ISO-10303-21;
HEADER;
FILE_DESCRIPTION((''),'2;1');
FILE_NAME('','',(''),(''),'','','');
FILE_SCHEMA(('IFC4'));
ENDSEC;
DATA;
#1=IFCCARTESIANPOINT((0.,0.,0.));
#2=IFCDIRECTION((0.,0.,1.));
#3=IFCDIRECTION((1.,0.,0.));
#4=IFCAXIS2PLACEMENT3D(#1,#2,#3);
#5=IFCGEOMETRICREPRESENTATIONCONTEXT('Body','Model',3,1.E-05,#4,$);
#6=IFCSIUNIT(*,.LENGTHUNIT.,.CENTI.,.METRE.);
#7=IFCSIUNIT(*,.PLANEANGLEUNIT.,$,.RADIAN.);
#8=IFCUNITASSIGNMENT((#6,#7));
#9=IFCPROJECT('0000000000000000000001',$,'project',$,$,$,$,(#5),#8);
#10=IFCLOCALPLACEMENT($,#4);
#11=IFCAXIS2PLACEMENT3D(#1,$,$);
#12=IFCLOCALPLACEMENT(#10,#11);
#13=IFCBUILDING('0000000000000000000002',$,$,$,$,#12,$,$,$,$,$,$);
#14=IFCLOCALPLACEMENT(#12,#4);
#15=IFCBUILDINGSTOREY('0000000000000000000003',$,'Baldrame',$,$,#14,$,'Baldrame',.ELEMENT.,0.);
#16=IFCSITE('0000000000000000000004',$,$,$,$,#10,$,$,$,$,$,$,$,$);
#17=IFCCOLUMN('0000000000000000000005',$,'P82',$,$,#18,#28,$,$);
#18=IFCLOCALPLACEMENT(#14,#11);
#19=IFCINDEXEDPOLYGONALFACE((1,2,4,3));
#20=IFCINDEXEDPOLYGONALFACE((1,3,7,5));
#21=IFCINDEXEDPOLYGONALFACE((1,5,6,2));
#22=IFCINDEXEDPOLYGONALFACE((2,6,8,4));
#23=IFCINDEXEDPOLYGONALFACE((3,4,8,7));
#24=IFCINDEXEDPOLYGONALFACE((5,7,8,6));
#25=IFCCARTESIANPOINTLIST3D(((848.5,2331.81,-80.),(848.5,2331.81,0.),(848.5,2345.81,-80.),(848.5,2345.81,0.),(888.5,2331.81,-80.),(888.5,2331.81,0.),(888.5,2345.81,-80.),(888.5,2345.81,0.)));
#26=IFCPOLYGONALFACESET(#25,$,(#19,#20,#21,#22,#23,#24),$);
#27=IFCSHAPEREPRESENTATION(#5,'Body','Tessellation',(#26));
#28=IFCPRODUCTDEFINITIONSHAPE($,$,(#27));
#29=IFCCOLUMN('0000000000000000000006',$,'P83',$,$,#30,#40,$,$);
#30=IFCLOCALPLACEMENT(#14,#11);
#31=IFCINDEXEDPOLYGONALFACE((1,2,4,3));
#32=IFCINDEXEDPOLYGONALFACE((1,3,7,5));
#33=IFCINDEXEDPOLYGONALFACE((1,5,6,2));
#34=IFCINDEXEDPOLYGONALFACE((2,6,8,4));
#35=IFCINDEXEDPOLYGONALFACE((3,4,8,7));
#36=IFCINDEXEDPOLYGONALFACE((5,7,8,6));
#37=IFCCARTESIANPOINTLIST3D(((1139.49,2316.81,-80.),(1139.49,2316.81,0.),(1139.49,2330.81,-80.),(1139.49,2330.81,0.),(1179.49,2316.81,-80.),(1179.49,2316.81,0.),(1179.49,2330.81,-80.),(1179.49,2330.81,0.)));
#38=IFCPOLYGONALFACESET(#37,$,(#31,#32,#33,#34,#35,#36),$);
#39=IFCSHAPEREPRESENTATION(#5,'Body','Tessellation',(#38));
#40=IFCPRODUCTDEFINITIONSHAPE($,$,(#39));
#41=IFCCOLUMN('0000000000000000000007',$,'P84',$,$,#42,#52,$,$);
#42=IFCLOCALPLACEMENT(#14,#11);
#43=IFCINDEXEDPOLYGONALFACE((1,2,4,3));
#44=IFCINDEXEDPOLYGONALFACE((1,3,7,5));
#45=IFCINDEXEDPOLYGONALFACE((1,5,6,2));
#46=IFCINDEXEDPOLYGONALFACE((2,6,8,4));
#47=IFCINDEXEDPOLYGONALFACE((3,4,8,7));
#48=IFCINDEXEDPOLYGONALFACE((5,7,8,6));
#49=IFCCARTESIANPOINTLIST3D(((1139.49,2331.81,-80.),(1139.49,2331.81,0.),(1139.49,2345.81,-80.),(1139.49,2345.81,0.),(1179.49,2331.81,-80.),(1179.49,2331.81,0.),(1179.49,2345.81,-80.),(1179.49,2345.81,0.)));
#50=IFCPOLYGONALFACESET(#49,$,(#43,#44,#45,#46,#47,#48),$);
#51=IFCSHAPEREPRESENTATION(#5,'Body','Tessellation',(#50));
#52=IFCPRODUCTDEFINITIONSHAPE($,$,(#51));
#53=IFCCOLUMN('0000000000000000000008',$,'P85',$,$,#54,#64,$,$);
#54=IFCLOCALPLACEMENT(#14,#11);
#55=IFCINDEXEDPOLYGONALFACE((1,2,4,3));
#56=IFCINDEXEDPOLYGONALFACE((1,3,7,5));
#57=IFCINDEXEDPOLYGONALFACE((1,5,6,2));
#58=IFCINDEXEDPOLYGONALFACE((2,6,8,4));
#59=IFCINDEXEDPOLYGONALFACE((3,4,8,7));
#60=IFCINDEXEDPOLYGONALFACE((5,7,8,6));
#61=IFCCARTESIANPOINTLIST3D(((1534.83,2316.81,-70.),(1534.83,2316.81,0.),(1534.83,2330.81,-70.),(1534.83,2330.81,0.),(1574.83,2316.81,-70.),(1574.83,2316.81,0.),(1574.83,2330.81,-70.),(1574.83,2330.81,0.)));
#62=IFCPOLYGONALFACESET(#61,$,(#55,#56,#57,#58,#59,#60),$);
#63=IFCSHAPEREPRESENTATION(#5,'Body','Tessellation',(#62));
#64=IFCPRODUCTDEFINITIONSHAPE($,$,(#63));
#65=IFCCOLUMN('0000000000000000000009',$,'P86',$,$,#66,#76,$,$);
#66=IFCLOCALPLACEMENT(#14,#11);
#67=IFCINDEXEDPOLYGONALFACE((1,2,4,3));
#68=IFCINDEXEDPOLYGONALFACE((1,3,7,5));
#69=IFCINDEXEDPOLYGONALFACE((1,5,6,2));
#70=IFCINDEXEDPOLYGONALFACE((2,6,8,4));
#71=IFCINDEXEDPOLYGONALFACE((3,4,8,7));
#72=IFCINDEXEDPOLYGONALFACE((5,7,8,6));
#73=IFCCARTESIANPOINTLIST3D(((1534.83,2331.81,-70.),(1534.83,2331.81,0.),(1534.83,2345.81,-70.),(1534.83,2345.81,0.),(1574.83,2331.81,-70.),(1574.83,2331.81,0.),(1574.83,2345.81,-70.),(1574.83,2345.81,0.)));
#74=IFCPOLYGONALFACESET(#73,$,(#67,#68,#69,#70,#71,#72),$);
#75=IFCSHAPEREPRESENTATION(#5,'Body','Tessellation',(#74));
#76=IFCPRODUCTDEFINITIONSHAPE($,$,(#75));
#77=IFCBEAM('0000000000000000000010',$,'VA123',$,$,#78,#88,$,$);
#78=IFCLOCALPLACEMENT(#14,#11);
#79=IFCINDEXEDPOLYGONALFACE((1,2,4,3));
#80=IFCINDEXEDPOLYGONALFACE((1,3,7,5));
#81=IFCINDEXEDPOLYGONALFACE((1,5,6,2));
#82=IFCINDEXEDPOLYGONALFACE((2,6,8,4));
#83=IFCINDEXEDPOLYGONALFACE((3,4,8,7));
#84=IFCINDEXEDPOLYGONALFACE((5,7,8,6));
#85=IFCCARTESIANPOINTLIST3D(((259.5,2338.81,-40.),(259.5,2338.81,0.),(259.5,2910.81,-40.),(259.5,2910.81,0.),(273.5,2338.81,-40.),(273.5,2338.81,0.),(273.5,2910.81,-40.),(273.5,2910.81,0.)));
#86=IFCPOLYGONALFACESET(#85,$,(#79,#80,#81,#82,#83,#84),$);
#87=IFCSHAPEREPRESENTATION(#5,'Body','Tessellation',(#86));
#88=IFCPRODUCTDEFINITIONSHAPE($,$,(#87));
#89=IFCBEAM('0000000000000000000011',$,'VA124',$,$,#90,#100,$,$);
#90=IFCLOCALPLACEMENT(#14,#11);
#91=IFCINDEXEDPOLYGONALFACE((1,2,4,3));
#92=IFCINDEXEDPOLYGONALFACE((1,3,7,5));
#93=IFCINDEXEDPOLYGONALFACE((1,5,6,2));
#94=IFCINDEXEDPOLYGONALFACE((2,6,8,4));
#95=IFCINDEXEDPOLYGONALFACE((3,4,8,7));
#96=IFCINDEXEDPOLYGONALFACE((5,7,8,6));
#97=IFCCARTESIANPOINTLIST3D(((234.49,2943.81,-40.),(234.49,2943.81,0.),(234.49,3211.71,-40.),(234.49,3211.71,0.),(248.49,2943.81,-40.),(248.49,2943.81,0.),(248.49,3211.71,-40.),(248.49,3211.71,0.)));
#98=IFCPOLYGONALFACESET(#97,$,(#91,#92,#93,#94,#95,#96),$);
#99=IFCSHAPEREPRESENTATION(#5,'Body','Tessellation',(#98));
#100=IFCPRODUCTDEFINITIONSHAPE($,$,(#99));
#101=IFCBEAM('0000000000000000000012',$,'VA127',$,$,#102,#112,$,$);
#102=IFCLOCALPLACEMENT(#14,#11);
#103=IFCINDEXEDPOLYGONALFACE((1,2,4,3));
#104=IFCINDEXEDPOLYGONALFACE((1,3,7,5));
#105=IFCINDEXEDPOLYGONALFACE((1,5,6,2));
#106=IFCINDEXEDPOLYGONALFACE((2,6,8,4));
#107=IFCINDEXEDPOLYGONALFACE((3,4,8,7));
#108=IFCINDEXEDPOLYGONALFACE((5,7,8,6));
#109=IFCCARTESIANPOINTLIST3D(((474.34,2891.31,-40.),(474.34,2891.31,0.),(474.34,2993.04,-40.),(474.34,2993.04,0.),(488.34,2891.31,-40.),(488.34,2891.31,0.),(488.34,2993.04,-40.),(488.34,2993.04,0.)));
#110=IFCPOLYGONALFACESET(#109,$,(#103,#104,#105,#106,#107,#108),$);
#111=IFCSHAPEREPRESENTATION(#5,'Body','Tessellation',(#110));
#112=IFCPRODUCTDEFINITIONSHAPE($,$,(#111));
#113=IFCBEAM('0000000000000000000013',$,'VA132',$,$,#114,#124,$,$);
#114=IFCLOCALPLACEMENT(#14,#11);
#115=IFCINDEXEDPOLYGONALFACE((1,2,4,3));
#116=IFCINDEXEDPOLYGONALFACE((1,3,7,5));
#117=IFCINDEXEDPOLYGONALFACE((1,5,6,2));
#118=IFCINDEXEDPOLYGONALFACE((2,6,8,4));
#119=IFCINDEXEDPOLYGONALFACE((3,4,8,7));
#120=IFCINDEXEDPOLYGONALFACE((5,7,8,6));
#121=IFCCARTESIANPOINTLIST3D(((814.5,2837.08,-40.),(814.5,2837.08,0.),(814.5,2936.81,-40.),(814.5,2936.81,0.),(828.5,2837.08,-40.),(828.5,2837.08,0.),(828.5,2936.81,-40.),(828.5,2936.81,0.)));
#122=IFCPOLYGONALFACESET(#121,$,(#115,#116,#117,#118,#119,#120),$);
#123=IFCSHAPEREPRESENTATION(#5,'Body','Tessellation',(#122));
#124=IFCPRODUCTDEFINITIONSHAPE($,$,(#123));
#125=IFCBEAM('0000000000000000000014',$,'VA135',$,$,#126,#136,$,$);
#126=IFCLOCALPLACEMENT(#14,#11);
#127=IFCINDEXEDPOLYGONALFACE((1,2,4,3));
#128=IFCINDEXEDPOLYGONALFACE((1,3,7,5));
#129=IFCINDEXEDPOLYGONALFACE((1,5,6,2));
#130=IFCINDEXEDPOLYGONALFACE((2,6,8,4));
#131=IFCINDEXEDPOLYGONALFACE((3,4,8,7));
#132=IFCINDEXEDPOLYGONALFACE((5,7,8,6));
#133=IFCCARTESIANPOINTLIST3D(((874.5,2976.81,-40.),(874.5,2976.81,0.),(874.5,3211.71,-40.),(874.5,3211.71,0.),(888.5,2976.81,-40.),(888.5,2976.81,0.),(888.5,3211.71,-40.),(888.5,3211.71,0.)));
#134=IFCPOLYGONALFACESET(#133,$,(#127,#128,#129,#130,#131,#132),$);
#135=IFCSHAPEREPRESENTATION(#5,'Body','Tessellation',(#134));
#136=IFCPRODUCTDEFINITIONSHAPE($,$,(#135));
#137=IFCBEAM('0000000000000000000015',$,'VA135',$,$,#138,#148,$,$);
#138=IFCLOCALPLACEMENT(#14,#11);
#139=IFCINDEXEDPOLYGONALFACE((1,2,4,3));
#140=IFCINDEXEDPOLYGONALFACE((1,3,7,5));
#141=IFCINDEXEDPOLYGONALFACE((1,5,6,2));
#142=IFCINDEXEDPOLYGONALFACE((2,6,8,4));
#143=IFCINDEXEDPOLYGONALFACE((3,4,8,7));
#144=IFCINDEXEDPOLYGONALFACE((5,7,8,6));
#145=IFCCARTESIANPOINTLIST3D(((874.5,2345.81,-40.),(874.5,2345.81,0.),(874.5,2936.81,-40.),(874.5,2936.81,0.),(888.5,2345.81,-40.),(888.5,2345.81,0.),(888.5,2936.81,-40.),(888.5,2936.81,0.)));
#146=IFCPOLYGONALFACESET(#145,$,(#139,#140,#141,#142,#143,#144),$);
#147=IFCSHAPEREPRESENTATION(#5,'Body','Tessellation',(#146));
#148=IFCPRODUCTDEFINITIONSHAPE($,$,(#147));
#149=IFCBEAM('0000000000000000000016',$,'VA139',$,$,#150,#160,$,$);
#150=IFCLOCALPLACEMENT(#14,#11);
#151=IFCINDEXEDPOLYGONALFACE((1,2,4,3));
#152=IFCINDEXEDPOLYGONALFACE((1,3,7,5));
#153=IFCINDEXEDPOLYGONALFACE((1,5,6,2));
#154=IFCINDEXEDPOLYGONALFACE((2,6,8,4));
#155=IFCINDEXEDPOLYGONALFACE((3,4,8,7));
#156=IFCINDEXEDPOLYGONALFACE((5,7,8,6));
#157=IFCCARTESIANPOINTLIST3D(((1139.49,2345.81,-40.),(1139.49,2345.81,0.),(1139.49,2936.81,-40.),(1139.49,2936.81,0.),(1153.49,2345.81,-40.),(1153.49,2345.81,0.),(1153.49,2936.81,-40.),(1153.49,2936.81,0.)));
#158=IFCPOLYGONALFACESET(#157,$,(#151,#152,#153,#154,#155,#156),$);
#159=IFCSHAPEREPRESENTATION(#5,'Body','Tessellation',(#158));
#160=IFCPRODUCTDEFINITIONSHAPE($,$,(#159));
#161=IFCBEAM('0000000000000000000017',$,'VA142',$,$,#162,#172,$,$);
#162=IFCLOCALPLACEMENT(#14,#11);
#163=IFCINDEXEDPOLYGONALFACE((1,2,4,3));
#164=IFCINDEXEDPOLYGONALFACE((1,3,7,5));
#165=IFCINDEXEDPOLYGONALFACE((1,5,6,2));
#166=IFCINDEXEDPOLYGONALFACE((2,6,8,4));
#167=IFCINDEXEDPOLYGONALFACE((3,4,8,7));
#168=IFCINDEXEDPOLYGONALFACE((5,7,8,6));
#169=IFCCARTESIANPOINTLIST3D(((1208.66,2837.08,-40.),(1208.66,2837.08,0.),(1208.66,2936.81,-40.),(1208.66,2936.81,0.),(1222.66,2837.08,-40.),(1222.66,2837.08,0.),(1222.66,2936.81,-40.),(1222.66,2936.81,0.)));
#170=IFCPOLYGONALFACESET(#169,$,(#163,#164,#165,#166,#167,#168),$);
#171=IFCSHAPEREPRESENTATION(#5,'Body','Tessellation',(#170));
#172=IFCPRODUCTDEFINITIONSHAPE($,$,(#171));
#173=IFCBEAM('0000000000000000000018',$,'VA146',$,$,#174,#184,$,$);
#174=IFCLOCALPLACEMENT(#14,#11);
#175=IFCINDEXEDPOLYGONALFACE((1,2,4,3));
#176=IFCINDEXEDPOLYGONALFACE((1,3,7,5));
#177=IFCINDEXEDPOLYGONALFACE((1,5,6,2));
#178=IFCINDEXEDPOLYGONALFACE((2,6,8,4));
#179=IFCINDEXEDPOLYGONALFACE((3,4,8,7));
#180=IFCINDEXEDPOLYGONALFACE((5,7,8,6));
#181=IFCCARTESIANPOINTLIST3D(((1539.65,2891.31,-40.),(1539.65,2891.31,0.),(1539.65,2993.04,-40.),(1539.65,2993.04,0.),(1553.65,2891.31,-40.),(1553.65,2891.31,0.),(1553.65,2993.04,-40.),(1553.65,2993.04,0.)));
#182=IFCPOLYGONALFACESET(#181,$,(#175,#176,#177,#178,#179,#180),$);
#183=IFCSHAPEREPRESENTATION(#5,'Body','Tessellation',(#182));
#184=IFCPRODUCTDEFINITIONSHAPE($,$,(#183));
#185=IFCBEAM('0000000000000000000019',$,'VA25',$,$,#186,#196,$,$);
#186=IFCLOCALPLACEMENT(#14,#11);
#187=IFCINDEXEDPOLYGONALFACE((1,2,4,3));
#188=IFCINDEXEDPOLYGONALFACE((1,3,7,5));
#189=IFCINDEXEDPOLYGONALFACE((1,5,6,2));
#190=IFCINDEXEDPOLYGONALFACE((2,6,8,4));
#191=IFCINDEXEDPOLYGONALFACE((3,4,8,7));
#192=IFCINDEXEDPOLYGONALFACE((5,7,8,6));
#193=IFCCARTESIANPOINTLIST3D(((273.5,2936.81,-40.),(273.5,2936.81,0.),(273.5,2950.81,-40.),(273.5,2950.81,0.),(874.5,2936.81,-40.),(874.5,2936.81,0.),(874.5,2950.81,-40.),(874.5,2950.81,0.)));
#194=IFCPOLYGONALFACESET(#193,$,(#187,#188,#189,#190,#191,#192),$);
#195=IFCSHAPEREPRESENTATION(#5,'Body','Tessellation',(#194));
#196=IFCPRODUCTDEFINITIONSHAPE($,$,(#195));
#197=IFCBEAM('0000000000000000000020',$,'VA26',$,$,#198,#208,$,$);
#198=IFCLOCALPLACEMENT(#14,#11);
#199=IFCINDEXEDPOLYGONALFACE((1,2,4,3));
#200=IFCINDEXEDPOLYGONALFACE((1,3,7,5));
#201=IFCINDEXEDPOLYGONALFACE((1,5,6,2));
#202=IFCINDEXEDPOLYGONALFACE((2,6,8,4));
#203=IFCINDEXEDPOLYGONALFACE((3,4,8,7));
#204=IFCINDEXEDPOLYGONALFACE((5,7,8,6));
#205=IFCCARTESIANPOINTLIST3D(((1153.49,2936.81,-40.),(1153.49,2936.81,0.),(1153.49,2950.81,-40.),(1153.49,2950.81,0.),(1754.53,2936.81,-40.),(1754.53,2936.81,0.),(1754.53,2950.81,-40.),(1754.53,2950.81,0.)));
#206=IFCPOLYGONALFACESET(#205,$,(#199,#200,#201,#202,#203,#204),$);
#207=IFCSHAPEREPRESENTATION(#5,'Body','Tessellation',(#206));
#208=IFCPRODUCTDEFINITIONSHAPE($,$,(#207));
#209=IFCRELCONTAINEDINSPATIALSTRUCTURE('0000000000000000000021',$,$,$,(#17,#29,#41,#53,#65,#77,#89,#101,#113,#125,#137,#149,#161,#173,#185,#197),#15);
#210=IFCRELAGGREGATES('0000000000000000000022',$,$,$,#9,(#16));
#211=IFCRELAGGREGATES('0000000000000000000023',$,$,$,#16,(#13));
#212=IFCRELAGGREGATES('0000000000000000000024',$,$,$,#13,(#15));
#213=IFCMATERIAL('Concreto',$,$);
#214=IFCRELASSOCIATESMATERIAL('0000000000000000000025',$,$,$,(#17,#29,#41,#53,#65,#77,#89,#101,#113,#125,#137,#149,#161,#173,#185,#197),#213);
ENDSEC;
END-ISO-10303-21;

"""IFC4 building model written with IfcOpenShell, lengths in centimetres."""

from ifc_helpers import new_model, si_unit, frame, origin, origin_with_axes, origin_2d_with_axis, place, context, project, spatial, rectangle, extrude, material, element, save


model = new_model("IFC4")

# Units and contexts
model_context = context("Model", 3, precision=1e-05, world=origin_with_axes(), identifier="Body")
ifc_project = project(units=[si_unit("LENGTHUNIT", "METRE", prefix="CENTI"), si_unit("PLANEANGLEUNIT", "RADIAN")], contexts=[model_context])

# Site, building, storey
site_placement = place(None, origin_with_axes())
site = spatial("IfcSite", under=ifc_project, at=site_placement)
building_placement = place(site_placement, origin())
building = spatial("IfcBuilding", under=site, at=building_placement)
storey_placement = place(building_placement, origin_with_axes())
storey = spatial("IfcBuildingStorey", under=building, at=storey_placement, Name="Baldrame", LongName="Baldrame", CompositionType="ELEMENT", Elevation=0.0)

# Shared definitions
ifc_material = material(Name="Concreto")

# Columns
for number, where, z_axis, x_axis, name in (
    (1, (868.5, 2338.81, 0.0), (0.0, 0.0, 1.0), (1.0, 0.0, 0.0), "P82"),
    (2, (1159.49, 2323.81, 0.0), (0.0, 0.0, 1.0), (1.0, 0.0, 0.0), "P83"),
    (3, (1159.49, 2338.81, 0.0), (0.0, 0.0, 1.0), (1.0, 0.0, 0.0), "P84"),
):
    element("IfcColumn", number, at=place(storey_placement, frame(where, z_axis=z_axis, x_axis=x_axis)), inside=storey, material=ifc_material, Name=name, context=model_context, shape_type="SolidModel", body=[
        extrude(rectangle(XDim=14.0, YDim=40.0, at=origin_2d_with_axis()), frame((0.0, 0.0, -80.0), z_axis=(0.0, 0.0, 1.0), x_axis=(0.0, -1.0, 0.0)), (0.0, 0.0, 1.0), 80.0),
    ])
for number, where, z_axis, x_axis, name in (
    (4, (1554.83, 2323.81, 0.0), (0.0, 0.0, 1.0), (1.0, 0.0, 0.0), "P85"),
    (5, (1554.83, 2338.81, 0.0), (0.0, 0.0, 1.0), (1.0, 0.0, 0.0), "P86"),
):
    element("IfcColumn", number, at=place(storey_placement, frame(where, z_axis=z_axis, x_axis=x_axis)), inside=storey, material=ifc_material, Name=name, context=model_context, shape_type="SolidModel", body=[
        extrude(rectangle(XDim=14.0, YDim=40.0, at=origin_2d_with_axis()), frame((0.0, 0.0, -70.0), z_axis=(0.0, 0.0, 1.0), x_axis=(0.0, -1.0, 0.0)), (0.0, 0.0, 1.0), 70.0),
    ])

# Beams
beam_1_placement = place(storey_placement, frame((266.5, 2624.81, 0.0), z_axis=(0.0, 0.0, 1.0), x_axis=(1.0, 0.0, 0.0)))
element("IfcBeam", 6, at=beam_1_placement, inside=storey, material=ifc_material, Name="VA123", context=model_context, shape_type="SolidModel", body=[
    extrude(rectangle(XDim=14.0, YDim=40.0, at=origin_2d_with_axis()), frame((0.0, -286.0, -20.0), z_axis=(0.0, 1.0, 0.0), x_axis=(-1.0, 0.0, 0.0)), (0.0, 0.0, 1.0), 572.0),
])
beam_2_placement = place(storey_placement, frame((241.49, 3077.76, 0.0), z_axis=(0.0, 0.0, 1.0), x_axis=(1.0, 0.0, 0.0)))
element("IfcBeam", 7, at=beam_2_placement, inside=storey, material=ifc_material, Name="VA124", context=model_context, shape_type="SolidModel", body=[
    extrude(rectangle(XDim=14.0, YDim=40.0, at=origin_2d_with_axis()), frame((0.0, -133.95, -20.0), z_axis=(0.0, 1.0, 0.0), x_axis=(-1.0, 0.0, 0.0)), (0.0, 0.0, 1.0), 267.9),
])
beam_3_placement = place(storey_placement, frame((481.34, 2942.18, 0.0), z_axis=(0.0, 0.0, 1.0), x_axis=(1.0, 0.0, 0.0)))
element("IfcBeam", 8, at=beam_3_placement, inside=storey, material=ifc_material, Name="VA127", context=model_context, shape_type="SolidModel", body=[
    extrude(rectangle(XDim=14.0, YDim=40.0, at=origin_2d_with_axis()), frame((0.0, -50.87, -20.0), z_axis=(0.0, 1.0, 0.0), x_axis=(-1.0, 0.0, 0.0)), (0.0, 0.0, 1.0), 101.73),
])
beam_4_placement = place(storey_placement, frame((821.5, 2886.94, 0.0), z_axis=(0.0, 0.0, 1.0), x_axis=(1.0, 0.0, 0.0)))
element("IfcBeam", 9, at=beam_4_placement, inside=storey, material=ifc_material, Name="VA132", context=model_context, shape_type="SolidModel", body=[
    extrude(rectangle(XDim=14.0, YDim=40.0, at=origin_2d_with_axis()), frame((0.0, -49.87, -20.0), z_axis=(0.0, 1.0, 0.0), x_axis=(-1.0, 0.0, 0.0)), (0.0, 0.0, 1.0), 99.73),
])
beam_5_placement = place(storey_placement, frame((881.5, 3094.26, 0.0), z_axis=(0.0, 0.0, 1.0), x_axis=(1.0, 0.0, 0.0)))
element("IfcBeam", 10, at=beam_5_placement, inside=storey, material=ifc_material, Name="VA135", context=model_context, shape_type="SolidModel", body=[
    extrude(rectangle(XDim=14.0, YDim=40.0, at=origin_2d_with_axis()), frame((0.0, -117.45, -20.0), z_axis=(0.0, 1.0, 0.0), x_axis=(-1.0, 0.0, 0.0)), (0.0, 0.0, 1.0), 234.9),
])
for number, where, z_axis, x_axis, name in (
    (11, (881.5, 2641.31, 0.0), (0.0, 0.0, 1.0), (1.0, 0.0, 0.0), "VA135"),
    (12, (1146.49, 2641.31, 0.0), (0.0, 0.0, 1.0), (1.0, 0.0, 0.0), "VA139"),
):
    element("IfcBeam", number, at=place(storey_placement, frame(where, z_axis=z_axis, x_axis=x_axis)), inside=storey, material=ifc_material, Name=name, context=model_context, shape_type="SolidModel", body=[
        extrude(rectangle(XDim=14.0, YDim=40.0, at=origin_2d_with_axis()), frame((0.0, -295.5, -20.0), z_axis=(0.0, 1.0, 0.0), x_axis=(-1.0, 0.0, 0.0)), (0.0, 0.0, 1.0), 591.0),
    ])
beam_6_placement = place(storey_placement, frame((1215.66, 2886.94, 0.0), z_axis=(0.0, 0.0, 1.0), x_axis=(1.0, 0.0, 0.0)))
element("IfcBeam", 13, at=beam_6_placement, inside=storey, material=ifc_material, Name="VA142", context=model_context, shape_type="SolidModel", body=[
    extrude(rectangle(XDim=14.0, YDim=40.0, at=origin_2d_with_axis()), frame((0.0, -49.87, -20.0), z_axis=(0.0, 1.0, 0.0), x_axis=(-1.0, 0.0, 0.0)), (0.0, 0.0, 1.0), 99.73),
])
beam_7_placement = place(storey_placement, frame((1546.65, 2942.18, 0.0), z_axis=(0.0, 0.0, 1.0), x_axis=(1.0, 0.0, 0.0)))
element("IfcBeam", 14, at=beam_7_placement, inside=storey, material=ifc_material, Name="VA146", context=model_context, shape_type="SolidModel", body=[
    extrude(rectangle(XDim=14.0, YDim=40.0, at=origin_2d_with_axis()), frame((0.0, -50.87, -20.0), z_axis=(0.0, 1.0, 0.0), x_axis=(-1.0, 0.0, 0.0)), (0.0, 0.0, 1.0), 101.73),
])
beam_8_placement = place(storey_placement, frame((574.0, 2943.81, 0.0), z_axis=(0.0, 0.0, 1.0), x_axis=(1.0, 0.0, 0.0)))
element("IfcBeam", 15, at=beam_8_placement, inside=storey, material=ifc_material, Name="VA25", context=model_context, shape_type="SolidModel", body=[
    extrude(rectangle(XDim=14.0, YDim=40.0, at=origin_2d_with_axis()), frame((-300.5, 0.0, -20.0), z_axis=(1.0, 0.0, 0.0), x_axis=(0.0, 1.0, 0.0)), (0.0, 0.0, 1.0), 601.0),
])
beam_9_placement = place(storey_placement, frame((1454.01, 2943.81, 0.0), z_axis=(0.0, 0.0, 1.0), x_axis=(1.0, 0.0, 0.0)))
element("IfcBeam", 16, at=beam_9_placement, inside=storey, material=ifc_material, Name="VA26", context=model_context, shape_type="SolidModel", body=[
    extrude(rectangle(XDim=14.0, YDim=40.0, at=origin_2d_with_axis()), frame((-300.52, 0.0, -20.0), z_axis=(1.0, 0.0, 0.0), x_axis=(0.0, 1.0, 0.0)), (0.0, 0.0, 1.0), 601.04),
])

save(model, "model.ifc")
